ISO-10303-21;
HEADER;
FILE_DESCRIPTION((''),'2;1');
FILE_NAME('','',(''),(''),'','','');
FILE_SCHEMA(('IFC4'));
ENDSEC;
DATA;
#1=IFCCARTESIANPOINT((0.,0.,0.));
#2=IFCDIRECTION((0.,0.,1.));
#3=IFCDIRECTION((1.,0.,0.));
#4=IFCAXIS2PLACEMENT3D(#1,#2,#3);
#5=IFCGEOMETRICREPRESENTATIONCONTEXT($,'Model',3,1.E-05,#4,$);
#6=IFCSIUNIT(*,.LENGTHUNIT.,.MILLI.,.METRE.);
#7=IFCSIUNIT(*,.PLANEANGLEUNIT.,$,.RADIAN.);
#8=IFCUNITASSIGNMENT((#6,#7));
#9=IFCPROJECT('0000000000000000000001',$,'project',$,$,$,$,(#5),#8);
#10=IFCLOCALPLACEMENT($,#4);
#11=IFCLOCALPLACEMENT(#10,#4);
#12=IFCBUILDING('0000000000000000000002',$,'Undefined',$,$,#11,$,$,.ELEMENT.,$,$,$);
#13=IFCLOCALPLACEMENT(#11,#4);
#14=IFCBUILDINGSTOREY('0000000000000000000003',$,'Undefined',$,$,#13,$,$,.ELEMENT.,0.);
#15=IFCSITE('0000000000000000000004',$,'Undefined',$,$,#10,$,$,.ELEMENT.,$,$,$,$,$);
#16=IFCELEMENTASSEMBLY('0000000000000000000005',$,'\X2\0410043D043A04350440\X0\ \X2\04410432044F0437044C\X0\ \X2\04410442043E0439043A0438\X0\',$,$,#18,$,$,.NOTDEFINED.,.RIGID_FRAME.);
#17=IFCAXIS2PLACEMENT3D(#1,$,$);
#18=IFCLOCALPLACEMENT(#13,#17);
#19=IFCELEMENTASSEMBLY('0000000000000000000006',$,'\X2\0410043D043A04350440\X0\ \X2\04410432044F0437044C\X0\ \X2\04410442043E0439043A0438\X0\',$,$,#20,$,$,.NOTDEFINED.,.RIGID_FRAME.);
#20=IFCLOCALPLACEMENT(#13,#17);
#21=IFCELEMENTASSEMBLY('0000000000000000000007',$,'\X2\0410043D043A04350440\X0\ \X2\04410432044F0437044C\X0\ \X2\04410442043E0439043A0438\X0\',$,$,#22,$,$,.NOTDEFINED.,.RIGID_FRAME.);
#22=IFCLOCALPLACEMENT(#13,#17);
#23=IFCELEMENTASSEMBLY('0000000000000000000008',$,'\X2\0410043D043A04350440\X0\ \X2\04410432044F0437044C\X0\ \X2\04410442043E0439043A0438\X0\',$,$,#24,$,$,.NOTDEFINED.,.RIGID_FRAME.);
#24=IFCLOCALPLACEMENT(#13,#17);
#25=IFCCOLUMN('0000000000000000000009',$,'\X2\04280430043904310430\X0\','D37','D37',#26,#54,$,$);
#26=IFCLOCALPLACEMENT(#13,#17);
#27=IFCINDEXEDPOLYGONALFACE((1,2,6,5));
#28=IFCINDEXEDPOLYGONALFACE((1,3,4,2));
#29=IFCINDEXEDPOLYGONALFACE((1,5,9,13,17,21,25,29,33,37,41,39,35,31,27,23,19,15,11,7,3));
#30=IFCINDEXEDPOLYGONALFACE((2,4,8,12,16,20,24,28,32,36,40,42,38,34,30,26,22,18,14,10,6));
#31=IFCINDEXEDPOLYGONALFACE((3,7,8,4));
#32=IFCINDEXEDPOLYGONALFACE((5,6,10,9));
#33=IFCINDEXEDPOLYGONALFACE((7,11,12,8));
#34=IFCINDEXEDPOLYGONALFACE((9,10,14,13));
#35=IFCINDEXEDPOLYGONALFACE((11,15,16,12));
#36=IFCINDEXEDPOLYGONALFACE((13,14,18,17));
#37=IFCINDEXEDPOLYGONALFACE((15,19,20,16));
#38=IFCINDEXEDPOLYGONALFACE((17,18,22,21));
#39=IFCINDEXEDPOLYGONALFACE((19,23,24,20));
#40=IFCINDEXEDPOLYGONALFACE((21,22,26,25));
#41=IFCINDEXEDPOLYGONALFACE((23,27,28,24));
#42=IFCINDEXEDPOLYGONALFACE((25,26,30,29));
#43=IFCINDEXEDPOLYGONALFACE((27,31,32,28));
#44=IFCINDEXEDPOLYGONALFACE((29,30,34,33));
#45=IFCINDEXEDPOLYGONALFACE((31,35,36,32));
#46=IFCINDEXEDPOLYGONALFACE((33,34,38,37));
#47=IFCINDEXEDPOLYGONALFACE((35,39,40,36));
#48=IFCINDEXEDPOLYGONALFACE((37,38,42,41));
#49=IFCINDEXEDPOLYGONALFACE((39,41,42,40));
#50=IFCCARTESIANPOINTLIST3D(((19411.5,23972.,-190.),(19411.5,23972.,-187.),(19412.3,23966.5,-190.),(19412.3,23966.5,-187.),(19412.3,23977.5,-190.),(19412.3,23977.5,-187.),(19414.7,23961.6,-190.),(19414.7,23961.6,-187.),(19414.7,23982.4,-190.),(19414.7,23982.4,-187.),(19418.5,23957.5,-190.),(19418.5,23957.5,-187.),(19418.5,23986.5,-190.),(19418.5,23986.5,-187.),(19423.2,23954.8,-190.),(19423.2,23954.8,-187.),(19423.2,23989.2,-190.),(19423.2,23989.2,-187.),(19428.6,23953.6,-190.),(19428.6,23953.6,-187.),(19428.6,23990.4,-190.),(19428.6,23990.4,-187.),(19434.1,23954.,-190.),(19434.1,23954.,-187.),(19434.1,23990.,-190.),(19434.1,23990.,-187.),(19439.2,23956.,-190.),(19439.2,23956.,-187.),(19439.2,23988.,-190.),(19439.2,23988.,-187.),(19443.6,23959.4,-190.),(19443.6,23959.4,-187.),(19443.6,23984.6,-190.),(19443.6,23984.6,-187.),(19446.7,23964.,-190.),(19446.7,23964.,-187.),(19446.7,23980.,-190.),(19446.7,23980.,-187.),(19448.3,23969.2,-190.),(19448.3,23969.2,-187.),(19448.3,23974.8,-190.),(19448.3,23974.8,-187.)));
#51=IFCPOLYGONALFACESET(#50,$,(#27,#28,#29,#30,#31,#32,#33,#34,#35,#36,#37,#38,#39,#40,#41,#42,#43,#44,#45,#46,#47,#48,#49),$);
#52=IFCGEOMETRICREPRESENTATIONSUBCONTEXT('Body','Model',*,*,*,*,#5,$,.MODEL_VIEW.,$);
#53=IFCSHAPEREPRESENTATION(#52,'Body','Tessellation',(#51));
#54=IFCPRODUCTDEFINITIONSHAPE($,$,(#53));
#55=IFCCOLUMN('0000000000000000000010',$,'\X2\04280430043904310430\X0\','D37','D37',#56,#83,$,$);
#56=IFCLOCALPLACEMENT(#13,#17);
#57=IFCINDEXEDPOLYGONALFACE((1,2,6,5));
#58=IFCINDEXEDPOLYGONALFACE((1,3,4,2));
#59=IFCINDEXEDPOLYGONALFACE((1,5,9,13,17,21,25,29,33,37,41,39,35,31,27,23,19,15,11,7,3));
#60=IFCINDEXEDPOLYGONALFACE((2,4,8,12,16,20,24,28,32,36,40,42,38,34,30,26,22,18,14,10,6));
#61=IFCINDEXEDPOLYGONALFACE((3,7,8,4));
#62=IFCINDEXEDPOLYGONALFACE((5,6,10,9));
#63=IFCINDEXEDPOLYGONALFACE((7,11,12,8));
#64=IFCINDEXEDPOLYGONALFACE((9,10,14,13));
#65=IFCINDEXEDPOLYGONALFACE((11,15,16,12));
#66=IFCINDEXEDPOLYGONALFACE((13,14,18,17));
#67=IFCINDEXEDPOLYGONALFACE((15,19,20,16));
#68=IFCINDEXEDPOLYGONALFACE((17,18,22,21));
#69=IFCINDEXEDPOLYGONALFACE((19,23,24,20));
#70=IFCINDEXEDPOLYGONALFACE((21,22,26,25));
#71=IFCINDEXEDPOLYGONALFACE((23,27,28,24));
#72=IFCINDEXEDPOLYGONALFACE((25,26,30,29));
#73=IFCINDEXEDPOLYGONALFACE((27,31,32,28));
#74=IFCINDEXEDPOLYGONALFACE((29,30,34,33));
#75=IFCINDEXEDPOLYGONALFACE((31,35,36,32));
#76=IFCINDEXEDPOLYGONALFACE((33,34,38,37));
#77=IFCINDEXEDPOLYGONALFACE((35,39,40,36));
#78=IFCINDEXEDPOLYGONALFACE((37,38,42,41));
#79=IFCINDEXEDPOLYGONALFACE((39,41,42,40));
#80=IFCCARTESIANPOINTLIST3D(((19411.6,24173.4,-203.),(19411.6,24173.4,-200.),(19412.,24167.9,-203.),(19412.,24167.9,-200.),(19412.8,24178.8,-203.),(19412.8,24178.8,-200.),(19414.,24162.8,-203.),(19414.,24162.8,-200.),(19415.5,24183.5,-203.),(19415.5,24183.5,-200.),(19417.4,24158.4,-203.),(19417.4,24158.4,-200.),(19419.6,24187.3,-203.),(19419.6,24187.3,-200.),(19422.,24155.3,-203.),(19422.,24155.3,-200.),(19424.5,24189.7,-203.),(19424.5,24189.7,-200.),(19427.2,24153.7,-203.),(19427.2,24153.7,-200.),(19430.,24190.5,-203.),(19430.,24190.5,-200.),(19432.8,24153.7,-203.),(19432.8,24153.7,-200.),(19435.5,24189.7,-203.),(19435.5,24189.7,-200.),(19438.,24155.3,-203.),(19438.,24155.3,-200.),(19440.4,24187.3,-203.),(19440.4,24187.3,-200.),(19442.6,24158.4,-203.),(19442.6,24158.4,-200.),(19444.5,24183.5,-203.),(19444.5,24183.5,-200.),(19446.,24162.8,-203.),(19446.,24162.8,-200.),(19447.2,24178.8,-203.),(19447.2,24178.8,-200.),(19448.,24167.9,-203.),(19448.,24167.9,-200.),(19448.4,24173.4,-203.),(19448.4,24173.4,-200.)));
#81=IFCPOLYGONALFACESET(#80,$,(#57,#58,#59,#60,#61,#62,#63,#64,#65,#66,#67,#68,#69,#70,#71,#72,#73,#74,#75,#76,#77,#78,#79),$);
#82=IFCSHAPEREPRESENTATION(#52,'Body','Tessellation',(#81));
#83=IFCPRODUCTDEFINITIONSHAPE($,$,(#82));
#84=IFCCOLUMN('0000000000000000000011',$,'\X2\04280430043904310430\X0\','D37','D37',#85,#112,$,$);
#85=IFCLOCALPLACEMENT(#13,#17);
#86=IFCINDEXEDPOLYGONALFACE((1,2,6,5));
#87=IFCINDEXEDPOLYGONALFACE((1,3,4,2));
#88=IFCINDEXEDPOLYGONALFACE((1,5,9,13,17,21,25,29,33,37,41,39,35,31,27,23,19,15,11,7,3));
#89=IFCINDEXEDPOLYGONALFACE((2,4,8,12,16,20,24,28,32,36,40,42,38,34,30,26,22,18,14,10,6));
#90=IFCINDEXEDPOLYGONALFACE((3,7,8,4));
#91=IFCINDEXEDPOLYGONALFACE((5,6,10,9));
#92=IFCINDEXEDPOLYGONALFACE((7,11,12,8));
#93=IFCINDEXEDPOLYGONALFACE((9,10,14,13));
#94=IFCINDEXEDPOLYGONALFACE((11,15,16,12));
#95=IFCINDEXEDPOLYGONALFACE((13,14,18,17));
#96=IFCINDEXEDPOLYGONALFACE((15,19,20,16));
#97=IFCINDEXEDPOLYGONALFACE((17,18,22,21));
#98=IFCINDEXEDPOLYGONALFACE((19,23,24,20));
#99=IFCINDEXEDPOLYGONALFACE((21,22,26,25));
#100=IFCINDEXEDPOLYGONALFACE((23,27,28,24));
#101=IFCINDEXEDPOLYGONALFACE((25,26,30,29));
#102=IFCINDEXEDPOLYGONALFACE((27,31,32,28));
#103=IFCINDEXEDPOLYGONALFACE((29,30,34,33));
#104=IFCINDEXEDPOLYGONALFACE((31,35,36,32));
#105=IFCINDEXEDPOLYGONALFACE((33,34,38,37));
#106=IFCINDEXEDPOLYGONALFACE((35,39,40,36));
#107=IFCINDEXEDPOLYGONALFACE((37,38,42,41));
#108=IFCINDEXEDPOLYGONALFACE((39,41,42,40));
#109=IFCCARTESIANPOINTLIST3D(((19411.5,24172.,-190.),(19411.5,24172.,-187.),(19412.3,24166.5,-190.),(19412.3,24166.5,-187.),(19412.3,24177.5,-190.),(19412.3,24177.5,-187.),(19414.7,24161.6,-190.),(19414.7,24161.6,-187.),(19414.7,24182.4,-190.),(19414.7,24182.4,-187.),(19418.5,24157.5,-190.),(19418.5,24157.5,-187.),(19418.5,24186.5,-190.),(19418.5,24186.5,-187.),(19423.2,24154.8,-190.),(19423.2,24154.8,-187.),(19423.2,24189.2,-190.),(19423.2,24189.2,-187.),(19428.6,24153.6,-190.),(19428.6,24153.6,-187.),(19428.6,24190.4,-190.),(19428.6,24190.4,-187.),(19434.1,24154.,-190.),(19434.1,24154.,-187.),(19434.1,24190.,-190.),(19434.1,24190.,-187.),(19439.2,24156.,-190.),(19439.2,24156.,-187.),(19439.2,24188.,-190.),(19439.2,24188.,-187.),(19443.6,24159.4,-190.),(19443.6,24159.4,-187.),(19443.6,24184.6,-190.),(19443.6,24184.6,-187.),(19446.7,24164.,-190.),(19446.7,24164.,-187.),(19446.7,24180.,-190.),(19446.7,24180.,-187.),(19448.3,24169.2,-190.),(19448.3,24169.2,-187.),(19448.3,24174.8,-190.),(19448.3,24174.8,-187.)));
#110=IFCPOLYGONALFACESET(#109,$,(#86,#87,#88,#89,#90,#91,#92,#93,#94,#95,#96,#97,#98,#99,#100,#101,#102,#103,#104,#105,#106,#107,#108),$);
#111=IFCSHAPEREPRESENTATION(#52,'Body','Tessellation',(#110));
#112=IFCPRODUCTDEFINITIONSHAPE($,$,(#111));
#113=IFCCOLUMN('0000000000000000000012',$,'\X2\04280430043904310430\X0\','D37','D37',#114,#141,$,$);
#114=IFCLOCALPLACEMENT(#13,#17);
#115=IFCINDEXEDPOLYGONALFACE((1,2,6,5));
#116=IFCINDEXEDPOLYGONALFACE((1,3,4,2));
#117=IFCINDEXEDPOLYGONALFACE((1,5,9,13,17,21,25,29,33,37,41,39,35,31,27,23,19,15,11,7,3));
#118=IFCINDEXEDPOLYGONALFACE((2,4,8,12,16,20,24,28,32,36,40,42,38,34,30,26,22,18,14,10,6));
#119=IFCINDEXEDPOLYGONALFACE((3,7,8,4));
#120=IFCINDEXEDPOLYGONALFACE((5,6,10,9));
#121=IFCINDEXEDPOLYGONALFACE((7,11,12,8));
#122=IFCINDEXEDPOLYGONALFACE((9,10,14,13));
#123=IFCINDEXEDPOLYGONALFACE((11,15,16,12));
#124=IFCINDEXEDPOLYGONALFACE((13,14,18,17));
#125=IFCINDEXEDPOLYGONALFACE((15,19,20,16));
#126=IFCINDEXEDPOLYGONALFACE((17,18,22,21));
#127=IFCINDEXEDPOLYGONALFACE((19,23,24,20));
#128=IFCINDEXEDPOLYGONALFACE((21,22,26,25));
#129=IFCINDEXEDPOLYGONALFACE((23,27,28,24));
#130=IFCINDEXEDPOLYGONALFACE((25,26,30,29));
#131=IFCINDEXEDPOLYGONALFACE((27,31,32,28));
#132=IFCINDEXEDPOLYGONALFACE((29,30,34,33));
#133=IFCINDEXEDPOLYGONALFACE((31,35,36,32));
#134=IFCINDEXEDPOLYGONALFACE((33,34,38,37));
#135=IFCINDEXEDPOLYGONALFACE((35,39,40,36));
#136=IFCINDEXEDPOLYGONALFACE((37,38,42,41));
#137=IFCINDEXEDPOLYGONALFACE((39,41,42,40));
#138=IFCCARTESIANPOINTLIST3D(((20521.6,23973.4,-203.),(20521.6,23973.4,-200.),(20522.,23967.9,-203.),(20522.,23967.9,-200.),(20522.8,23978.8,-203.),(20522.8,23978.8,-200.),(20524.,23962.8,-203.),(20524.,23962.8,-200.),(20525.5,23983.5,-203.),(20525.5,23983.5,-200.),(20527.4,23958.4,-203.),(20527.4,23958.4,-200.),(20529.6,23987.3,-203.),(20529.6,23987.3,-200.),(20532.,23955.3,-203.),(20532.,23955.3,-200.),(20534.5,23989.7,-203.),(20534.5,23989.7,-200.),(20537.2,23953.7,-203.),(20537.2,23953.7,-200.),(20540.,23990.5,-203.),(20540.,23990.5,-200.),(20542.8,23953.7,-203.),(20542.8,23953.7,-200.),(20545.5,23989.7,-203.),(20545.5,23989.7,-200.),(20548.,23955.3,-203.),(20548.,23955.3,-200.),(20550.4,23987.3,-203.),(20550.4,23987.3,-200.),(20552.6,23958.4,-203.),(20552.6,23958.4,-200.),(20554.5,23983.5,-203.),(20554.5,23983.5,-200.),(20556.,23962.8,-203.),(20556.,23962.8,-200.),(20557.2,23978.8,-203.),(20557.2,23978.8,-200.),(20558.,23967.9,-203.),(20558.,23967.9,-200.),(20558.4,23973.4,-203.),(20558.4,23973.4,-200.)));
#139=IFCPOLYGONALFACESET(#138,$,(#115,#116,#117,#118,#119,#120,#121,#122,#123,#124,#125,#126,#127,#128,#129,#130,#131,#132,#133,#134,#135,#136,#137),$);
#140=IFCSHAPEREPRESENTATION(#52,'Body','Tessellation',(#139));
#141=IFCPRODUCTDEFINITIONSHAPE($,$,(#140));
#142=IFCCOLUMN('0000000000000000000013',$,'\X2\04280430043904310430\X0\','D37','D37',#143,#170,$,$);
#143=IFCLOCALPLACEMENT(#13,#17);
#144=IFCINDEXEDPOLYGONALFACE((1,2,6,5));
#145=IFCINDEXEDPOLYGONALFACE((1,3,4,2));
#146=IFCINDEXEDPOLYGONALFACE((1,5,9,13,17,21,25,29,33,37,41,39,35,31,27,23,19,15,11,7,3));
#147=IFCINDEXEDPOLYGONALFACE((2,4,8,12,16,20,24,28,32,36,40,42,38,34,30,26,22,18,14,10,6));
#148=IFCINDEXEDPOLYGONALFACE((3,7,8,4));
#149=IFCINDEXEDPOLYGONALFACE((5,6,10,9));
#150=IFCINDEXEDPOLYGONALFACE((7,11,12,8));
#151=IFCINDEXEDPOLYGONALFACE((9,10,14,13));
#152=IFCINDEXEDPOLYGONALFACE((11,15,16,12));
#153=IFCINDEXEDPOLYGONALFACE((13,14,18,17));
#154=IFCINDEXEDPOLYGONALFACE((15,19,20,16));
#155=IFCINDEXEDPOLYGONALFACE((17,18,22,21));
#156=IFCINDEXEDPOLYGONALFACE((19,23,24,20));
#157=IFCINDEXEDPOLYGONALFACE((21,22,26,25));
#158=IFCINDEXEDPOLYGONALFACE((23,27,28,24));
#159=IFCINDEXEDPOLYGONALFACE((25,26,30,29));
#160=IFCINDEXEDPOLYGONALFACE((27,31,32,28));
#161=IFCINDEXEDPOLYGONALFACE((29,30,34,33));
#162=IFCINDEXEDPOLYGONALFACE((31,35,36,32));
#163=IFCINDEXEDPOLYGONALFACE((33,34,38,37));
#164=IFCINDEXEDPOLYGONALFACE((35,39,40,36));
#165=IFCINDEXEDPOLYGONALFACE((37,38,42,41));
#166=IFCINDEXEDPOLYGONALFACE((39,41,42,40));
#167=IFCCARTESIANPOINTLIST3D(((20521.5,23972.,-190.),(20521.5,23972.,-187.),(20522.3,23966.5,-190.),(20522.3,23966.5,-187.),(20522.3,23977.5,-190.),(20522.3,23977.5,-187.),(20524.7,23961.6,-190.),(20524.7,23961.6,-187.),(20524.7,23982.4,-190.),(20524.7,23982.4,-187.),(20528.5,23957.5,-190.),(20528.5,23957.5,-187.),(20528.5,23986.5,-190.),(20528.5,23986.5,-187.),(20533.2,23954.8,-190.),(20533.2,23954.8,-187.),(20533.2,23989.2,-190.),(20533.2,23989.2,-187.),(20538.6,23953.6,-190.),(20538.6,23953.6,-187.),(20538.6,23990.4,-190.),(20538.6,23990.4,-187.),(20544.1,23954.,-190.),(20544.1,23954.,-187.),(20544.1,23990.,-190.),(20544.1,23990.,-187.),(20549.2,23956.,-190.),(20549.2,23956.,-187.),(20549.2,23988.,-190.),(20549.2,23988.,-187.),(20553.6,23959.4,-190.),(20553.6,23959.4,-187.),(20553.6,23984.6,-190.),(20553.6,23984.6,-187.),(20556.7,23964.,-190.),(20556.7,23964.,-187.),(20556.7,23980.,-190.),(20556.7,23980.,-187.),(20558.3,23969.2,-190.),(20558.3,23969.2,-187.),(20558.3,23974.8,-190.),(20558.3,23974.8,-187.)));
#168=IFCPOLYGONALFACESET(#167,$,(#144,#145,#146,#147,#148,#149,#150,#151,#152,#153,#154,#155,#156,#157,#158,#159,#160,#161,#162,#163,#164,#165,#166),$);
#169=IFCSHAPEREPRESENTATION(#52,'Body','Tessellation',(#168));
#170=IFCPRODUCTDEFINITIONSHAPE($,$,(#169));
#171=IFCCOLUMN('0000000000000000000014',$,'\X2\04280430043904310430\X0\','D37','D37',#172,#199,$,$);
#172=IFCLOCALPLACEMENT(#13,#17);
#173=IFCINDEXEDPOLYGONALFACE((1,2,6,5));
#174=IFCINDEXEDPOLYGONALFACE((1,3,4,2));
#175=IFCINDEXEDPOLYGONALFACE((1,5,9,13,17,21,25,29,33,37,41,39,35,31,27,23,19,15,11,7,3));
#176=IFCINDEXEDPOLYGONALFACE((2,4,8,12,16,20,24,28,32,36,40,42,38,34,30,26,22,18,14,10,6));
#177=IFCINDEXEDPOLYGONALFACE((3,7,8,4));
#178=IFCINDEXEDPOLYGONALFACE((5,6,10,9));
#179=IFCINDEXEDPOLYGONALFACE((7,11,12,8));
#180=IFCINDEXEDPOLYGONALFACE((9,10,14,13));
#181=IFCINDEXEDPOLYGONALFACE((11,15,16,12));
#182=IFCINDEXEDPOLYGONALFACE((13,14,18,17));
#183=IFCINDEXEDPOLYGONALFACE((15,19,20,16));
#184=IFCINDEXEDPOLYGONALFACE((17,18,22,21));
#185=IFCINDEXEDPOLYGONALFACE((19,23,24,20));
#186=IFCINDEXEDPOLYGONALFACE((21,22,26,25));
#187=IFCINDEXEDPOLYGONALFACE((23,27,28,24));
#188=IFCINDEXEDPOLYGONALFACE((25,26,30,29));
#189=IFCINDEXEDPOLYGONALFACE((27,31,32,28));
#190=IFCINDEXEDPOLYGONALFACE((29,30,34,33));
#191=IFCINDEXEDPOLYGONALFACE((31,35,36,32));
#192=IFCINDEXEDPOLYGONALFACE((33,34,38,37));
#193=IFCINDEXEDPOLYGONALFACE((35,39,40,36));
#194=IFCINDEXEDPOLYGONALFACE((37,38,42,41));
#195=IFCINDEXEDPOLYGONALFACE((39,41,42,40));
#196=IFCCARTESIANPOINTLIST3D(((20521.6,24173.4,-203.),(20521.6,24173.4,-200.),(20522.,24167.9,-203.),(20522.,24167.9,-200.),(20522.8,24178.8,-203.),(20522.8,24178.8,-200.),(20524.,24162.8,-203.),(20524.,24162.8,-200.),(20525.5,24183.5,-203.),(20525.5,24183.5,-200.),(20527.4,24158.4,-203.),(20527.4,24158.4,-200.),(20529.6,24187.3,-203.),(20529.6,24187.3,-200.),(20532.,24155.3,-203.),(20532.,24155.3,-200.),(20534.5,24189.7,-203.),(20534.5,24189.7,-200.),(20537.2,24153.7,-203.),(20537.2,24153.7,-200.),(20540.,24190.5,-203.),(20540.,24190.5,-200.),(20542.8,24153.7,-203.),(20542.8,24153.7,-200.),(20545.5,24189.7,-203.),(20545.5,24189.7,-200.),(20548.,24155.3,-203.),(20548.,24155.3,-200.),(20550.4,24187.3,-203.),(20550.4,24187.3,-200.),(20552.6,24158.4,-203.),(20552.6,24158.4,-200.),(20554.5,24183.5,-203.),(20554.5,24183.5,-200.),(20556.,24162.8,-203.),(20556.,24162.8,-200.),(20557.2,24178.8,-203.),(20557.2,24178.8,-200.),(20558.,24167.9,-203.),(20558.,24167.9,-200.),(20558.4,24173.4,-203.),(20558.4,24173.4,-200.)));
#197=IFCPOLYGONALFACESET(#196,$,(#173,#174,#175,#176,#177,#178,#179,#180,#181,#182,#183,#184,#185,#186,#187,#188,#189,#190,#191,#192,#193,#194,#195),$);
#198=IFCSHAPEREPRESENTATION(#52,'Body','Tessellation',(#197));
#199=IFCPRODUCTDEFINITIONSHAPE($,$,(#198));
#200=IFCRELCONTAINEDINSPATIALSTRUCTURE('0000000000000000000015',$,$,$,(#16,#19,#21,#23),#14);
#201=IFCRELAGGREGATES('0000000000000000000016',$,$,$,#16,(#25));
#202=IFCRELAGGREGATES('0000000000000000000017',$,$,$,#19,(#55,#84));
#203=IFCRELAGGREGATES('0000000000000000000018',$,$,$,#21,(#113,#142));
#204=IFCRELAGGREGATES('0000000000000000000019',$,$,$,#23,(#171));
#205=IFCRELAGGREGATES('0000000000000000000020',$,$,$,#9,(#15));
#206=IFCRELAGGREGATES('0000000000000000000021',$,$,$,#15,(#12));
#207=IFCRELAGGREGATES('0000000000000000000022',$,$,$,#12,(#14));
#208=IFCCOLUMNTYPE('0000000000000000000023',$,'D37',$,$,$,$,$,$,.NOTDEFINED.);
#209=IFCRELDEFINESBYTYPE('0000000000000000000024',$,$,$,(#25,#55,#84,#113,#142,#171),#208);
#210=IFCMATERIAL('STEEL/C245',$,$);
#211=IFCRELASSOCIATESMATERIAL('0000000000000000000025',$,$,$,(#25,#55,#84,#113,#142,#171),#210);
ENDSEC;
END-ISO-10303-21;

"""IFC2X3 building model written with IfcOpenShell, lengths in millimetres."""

from ifc_helpers import new_model, si_unit, frame, origin_with_axes, origin_2d_with_axis, place, context, subcontext, project, spatial, circle, extrude, material, type_object, element, aggregate, save


model = new_model("IFC2X3")

# Units and contexts
model_context = context("Model", 3, precision=1e-05, world=origin_with_axes())
body_context = subcontext(model_context, "Body", "Model", "MODEL_VIEW")
ifc_project = project(units=[si_unit("LENGTHUNIT", "METRE", prefix="MILLI"), si_unit("PLANEANGLEUNIT", "RADIAN")], contexts=[model_context])

# Site, building, storey
site_placement = place(None, origin_with_axes())
site = spatial("IfcSite", under=ifc_project, at=site_placement, Name="Undefined", CompositionType="ELEMENT")
building_placement = place(site_placement, origin_with_axes())
building = spatial("IfcBuilding", under=site, at=building_placement, Name="Undefined", CompositionType="ELEMENT")
storey_placement = place(building_placement, origin_with_axes())
storey = spatial("IfcBuildingStorey", under=building, at=storey_placement, Name="Undefined", CompositionType="ELEMENT", Elevation=0.0)

# Element assemblies
assembly_1_placement = place(storey_placement, origin_with_axes())
assembly_1 = element("IfcElementAssembly", 1, at=assembly_1_placement, inside=storey, Name="Анкер связь стойки", AssemblyPlace="NOTDEFINED", PredefinedType="RIGID_FRAME")
ifc_material_1 = material(Name="STEEL/C245")
assembly_2_placement = place(storey_placement, origin_with_axes())
assembly_2 = element("IfcElementAssembly", 2, at=assembly_2_placement, inside=storey, Name="Анкер связь стойки", AssemblyPlace="NOTDEFINED", PredefinedType="RIGID_FRAME")
assembly_3_placement = place(storey_placement, origin_with_axes())
assembly_3 = element("IfcElementAssembly", 3, at=assembly_3_placement, inside=storey, Name="Анкер связь стойки", AssemblyPlace="NOTDEFINED", PredefinedType="RIGID_FRAME")
assembly_4_placement = place(storey_placement, origin_with_axes())
assembly_4 = element("IfcElementAssembly", 4, at=assembly_4_placement, inside=storey, Name="Анкер связь стойки", AssemblyPlace="NOTDEFINED", PredefinedType="RIGID_FRAME")

# Columns
column_type_1 = type_object("IfcColumnType", Name="D37", PredefinedType="NOTDEFINED")
column_1_placement = place(assembly_1_placement, frame((19430.0, 23972.0, -187.0), z_axis=(0.0, 0.0, -1.0), x_axis=(0.0, -1.0, 0.0)))
column_1 = element("IfcColumn", 5, at=column_1_placement, type_object=column_type_1, material=ifc_material_1, Name="Шайба", Description="D37", ObjectType="D37", context=body_context, shape_type="SweptSolid", body=[
    extrude(circle(Radius=18.5, at=origin_2d_with_axis()), frame((0.0, 0.0, 3.0), z_axis=(0.0, 0.0, -1.0), x_axis=(0.0, 1.0, 0.0)), (0.0, 0.0, 1.0), 3.0),
])
column_2_placement = place(assembly_2_placement, frame((19430.0, 24172.0, -200.0), z_axis=(0.0, 0.0, -1.0), x_axis=(-1.0, 0.0, 0.0)))
column_2 = element("IfcColumn", 6, at=column_2_placement, type_object=column_type_1, material=ifc_material_1, Name="Шайба", Description="D37", ObjectType="D37", context=body_context, shape_type="SweptSolid", body=[
    extrude(circle(Radius=18.5, at=origin_2d_with_axis()), frame((0.0, 0.0, 3.0), z_axis=(0.0, 0.0, -1.0), x_axis=(0.0, 1.0, 0.0)), (0.0, 0.0, 1.0), 3.0),
])
column_3_placement = place(assembly_2_placement, frame((19430.0, 24172.0, -187.0), z_axis=(0.0, 0.0, -1.0), x_axis=(0.0, -1.0, 0.0)))
column_3 = element("IfcColumn", 7, at=column_3_placement, type_object=column_type_1, material=ifc_material_1, Name="Шайба", Description="D37", ObjectType="D37", context=body_context, shape_type="SweptSolid", body=[
    extrude(circle(Radius=18.5, at=origin_2d_with_axis()), frame((0.0, 0.0, 3.0), z_axis=(0.0, 0.0, -1.0), x_axis=(0.0, 1.0, 0.0)), (0.0, 0.0, 1.0), 3.0),
])
column_4_placement = place(assembly_3_placement, frame((20540.0, 23972.0, -200.0), z_axis=(0.0, 0.0, -1.0), x_axis=(-1.0, 0.0, 0.0)))
column_4 = element("IfcColumn", 8, at=column_4_placement, type_object=column_type_1, material=ifc_material_1, Name="Шайба", Description="D37", ObjectType="D37", context=body_context, shape_type="SweptSolid", body=[
    extrude(circle(Radius=18.5, at=origin_2d_with_axis()), frame((0.0, 0.0, 3.0), z_axis=(0.0, 0.0, -1.0), x_axis=(0.0, 1.0, 0.0)), (0.0, 0.0, 1.0), 3.0),
])
column_5_placement = place(assembly_3_placement, frame((20540.0, 23972.0, -187.0), z_axis=(0.0, 0.0, -1.0), x_axis=(0.0, -1.0, 0.0)))
column_5 = element("IfcColumn", 9, at=column_5_placement, type_object=column_type_1, material=ifc_material_1, Name="Шайба", Description="D37", ObjectType="D37", context=body_context, shape_type="SweptSolid", body=[
    extrude(circle(Radius=18.5, at=origin_2d_with_axis()), frame((0.0, 0.0, 3.0), z_axis=(0.0, 0.0, -1.0), x_axis=(0.0, 1.0, 0.0)), (0.0, 0.0, 1.0), 3.0),
])
column_6_placement = place(assembly_4_placement, frame((20540.0, 24172.0, -200.0), z_axis=(0.0, 0.0, -1.0), x_axis=(-1.0, 0.0, 0.0)))
column_6 = element("IfcColumn", 10, at=column_6_placement, type_object=column_type_1, material=ifc_material_1, Name="Шайба", Description="D37", ObjectType="D37", context=body_context, shape_type="SweptSolid", body=[
    extrude(circle(Radius=18.5, at=origin_2d_with_axis()), frame((0.0, 0.0, 3.0), z_axis=(0.0, 0.0, -1.0), x_axis=(0.0, 1.0, 0.0)), (0.0, 0.0, 1.0), 3.0),
])

aggregate(assembly_1, [column_1])
aggregate(assembly_2, [column_2, column_3])
aggregate(assembly_3, [column_4, column_5])
aggregate(assembly_4, [column_6])

save(model, "model.ifc")
